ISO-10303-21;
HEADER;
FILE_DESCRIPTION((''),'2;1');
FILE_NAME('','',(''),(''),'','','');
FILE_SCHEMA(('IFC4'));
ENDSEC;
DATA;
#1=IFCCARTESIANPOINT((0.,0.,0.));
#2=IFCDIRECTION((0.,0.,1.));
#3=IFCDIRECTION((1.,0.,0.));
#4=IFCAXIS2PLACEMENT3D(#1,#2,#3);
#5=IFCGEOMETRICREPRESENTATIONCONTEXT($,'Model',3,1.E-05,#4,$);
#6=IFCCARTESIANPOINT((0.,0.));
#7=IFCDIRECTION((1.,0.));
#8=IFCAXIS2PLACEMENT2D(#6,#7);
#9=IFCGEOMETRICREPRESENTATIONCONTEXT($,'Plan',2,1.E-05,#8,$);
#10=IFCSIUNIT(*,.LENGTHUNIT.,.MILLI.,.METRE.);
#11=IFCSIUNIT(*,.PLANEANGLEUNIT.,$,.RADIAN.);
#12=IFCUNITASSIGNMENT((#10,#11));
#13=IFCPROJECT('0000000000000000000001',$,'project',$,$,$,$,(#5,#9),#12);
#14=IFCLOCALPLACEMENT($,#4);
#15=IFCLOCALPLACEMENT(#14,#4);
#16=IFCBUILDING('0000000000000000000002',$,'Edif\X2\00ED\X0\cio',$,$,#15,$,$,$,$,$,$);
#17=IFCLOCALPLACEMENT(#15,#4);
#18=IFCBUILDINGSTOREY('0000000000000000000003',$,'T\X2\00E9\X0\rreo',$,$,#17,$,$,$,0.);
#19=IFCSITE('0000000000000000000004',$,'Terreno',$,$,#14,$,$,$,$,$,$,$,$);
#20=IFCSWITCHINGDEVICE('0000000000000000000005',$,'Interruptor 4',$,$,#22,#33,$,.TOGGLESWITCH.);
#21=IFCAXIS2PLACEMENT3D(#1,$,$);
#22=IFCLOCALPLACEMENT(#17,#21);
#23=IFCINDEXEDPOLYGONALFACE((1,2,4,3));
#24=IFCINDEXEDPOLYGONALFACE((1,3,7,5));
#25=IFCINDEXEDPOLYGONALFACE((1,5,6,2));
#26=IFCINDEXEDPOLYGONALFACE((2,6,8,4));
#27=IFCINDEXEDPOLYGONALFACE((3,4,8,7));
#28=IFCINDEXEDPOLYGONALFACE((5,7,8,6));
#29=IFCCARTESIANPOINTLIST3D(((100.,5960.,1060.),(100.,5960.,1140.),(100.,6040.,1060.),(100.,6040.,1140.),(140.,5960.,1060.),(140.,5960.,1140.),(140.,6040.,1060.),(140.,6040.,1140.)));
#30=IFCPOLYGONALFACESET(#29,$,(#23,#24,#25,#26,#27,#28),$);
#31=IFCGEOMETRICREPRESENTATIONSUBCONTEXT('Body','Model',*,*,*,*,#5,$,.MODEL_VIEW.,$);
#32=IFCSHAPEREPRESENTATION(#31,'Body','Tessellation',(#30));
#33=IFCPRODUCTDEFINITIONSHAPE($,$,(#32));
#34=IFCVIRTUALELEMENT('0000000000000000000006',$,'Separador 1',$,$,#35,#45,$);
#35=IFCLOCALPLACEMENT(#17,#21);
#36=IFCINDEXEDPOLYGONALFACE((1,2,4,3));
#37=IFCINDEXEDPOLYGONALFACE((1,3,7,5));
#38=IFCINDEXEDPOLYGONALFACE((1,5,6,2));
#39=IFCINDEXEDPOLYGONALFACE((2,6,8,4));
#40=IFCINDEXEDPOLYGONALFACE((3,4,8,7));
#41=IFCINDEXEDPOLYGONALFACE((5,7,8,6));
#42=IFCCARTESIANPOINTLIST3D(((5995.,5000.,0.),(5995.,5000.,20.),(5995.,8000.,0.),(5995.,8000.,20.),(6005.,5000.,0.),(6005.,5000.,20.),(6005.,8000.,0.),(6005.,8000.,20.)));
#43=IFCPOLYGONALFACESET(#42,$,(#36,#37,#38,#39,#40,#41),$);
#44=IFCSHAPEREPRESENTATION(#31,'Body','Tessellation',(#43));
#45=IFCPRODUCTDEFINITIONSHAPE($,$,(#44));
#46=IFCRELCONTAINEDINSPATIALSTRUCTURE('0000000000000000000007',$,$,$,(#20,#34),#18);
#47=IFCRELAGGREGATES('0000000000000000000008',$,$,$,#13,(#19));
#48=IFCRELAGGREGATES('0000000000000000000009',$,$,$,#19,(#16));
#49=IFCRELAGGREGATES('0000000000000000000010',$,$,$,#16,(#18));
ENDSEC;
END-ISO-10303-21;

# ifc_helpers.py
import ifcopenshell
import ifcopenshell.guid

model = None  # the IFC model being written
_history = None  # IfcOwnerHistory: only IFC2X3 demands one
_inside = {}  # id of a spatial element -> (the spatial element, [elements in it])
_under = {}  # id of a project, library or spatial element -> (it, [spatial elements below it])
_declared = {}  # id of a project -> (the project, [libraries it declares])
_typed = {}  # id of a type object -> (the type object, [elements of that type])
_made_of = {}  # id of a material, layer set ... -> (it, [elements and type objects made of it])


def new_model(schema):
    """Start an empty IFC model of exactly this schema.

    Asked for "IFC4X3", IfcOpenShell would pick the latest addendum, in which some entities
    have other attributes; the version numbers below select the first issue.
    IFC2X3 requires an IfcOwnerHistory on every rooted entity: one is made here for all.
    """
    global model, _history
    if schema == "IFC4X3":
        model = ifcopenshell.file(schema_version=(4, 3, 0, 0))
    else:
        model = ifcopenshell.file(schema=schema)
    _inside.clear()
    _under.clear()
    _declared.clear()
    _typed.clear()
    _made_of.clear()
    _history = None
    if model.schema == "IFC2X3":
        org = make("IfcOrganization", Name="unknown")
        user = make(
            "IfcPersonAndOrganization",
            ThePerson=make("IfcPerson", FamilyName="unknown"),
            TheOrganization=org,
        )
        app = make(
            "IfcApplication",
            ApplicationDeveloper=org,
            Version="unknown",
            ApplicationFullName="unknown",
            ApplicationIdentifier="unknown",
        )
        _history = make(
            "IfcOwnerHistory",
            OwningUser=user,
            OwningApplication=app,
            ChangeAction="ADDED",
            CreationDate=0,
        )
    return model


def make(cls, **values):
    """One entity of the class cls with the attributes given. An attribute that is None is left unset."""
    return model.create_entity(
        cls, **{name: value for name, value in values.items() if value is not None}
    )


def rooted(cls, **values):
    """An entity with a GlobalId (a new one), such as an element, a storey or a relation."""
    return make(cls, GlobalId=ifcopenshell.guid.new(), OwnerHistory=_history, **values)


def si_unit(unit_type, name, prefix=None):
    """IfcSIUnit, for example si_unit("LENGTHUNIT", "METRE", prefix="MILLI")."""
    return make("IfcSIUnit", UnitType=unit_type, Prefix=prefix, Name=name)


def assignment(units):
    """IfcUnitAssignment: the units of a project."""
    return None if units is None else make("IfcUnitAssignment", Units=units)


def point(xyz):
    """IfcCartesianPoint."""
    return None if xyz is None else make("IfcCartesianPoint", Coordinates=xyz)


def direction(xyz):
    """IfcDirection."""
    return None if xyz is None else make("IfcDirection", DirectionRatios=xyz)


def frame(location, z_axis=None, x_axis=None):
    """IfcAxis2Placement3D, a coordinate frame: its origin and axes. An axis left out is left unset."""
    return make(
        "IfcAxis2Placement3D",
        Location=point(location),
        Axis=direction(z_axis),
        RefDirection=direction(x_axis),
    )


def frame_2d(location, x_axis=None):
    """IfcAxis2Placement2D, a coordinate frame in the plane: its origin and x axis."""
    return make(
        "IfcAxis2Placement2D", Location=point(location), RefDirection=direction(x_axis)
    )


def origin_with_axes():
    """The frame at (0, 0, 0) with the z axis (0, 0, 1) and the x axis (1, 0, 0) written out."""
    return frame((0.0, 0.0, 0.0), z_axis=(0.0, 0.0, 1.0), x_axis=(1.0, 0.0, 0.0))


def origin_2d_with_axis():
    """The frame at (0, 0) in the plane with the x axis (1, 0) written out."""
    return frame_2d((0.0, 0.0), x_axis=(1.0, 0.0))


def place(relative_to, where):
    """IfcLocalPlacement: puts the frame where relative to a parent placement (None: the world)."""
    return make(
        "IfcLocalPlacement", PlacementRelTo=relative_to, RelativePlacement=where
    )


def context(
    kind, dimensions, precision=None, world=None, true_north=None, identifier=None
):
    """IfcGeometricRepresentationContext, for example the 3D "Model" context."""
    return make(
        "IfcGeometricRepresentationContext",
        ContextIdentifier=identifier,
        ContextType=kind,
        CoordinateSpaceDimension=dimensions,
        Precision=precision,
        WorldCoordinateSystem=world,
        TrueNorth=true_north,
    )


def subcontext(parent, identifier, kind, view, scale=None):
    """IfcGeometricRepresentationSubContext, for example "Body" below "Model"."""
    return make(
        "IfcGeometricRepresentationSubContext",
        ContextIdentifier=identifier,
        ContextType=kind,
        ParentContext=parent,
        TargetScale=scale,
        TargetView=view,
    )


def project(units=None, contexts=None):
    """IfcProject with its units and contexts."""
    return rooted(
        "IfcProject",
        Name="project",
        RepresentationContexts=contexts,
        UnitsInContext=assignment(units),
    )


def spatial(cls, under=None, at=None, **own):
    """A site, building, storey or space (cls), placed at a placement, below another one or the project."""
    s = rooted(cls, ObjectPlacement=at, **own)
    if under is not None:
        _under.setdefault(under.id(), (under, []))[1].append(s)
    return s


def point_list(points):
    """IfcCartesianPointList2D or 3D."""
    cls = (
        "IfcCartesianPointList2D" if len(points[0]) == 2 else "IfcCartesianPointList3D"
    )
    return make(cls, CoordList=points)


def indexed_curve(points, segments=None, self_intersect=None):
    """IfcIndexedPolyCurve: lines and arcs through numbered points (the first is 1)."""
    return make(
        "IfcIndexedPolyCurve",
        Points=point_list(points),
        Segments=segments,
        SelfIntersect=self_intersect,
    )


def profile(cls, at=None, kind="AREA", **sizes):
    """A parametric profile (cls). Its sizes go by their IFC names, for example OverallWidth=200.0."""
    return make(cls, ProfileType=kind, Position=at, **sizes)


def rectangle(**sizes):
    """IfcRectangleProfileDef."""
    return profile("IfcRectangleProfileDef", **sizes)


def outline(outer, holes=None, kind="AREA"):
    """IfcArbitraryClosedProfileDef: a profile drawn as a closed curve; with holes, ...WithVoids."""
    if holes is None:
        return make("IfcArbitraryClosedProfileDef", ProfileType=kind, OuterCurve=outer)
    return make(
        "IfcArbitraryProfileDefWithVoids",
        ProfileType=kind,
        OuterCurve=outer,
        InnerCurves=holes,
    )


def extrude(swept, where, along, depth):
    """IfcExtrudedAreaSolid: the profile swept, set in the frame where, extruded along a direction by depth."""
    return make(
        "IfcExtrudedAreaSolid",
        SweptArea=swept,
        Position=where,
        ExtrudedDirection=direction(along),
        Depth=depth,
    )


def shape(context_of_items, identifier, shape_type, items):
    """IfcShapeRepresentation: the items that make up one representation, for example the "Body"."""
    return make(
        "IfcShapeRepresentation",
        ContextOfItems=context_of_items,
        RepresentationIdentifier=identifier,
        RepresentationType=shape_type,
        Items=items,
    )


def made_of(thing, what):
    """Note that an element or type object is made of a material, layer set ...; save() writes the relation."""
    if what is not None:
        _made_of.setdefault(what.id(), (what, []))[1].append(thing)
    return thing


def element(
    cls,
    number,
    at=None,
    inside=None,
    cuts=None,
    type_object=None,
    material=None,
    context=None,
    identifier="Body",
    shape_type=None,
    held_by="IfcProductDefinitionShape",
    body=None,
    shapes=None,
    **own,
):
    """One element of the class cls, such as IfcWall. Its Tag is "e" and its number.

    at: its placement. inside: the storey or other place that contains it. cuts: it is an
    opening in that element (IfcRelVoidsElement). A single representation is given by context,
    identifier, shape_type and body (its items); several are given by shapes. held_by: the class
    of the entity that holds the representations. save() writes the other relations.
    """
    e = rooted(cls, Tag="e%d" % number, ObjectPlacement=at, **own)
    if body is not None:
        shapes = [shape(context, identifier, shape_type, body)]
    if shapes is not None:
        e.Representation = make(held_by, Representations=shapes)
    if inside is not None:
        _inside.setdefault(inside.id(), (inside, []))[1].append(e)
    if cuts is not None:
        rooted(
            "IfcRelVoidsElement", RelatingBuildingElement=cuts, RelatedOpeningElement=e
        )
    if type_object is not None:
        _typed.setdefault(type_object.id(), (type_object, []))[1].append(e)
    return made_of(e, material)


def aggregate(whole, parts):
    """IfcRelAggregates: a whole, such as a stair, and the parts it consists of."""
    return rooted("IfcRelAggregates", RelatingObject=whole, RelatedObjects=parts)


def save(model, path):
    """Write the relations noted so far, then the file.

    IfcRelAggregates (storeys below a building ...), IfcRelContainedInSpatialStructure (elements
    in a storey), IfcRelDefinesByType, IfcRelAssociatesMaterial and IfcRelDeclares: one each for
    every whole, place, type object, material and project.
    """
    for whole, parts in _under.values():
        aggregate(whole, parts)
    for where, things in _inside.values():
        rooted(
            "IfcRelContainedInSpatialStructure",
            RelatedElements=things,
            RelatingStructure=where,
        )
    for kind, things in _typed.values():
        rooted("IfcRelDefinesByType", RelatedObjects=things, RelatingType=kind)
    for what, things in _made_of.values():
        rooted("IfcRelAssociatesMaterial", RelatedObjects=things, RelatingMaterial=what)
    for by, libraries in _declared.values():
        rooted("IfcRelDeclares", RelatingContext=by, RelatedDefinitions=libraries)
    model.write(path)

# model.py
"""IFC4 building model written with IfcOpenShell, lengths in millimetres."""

from ifc_helpers import new_model, si_unit, frame, frame_2d, origin_with_axes, origin_2d_with_axis, place, context, subcontext, project, spatial, indexed_curve, rectangle, outline, extrude, element, save


model = new_model("IFC4")

# Units and contexts
model_context = context("Model", 3, precision=1e-05, world=origin_with_axes())
plan_context = context("Plan", 2, precision=1e-05, world=origin_2d_with_axis())
body_context = subcontext(model_context, "Body", "Model", "MODEL_VIEW")
ifc_project = project(units=[si_unit("LENGTHUNIT", "METRE", prefix="MILLI"), si_unit("PLANEANGLEUNIT", "RADIAN")], contexts=[model_context, plan_context])

# Site, building, storey
site_placement = place(None, origin_with_axes())
site = spatial("IfcSite", under=ifc_project, at=site_placement, Name="Terreno")
building_placement = place(site_placement, origin_with_axes())
building = spatial("IfcBuilding", under=site, at=building_placement, Name="Edifício")
storey_placement = place(building_placement, origin_with_axes())
storey = spatial("IfcBuildingStorey", under=building, at=storey_placement, Name="Térreo", Elevation=0.0)

# Switching device
switching_device_placement = place(storey_placement, frame((100.0, 6000.0, 0.0), z_axis=(0.0, 0.0, 1.0), x_axis=(0.0, -1.0, 0.0)))
element("IfcSwitchingDevice", 1, at=switching_device_placement, inside=storey, Name="Interruptor 4", PredefinedType="TOGGLESWITCH", context=body_context, shape_type="SweptSolid", body=[
    extrude(rectangle(XDim=80.0, YDim=40.0, at=frame_2d((0.0, 20.0))), frame((0.0, 0.0, 1060.0)), (0.0, 0.0, 1.0), 80.0),
])

# Virtual element
virtual_element_placement = place(storey_placement, origin_with_axes())
element("IfcVirtualElement", 2, at=virtual_element_placement, inside=storey, Name="Separador 1", context=body_context, shape_type="SweptSolid", body=[
    extrude(outline(indexed_curve([(6005.0, 5000.0), (6005.0, 8000.0), (5995.0, 8000.0), (5995.0, 5000.0), (6005.0, 5000.0)], self_intersect=False)), origin_with_axes(), (0.0, 0.0, 1.0), 20.0),
])

save(model, "model.ifc")
